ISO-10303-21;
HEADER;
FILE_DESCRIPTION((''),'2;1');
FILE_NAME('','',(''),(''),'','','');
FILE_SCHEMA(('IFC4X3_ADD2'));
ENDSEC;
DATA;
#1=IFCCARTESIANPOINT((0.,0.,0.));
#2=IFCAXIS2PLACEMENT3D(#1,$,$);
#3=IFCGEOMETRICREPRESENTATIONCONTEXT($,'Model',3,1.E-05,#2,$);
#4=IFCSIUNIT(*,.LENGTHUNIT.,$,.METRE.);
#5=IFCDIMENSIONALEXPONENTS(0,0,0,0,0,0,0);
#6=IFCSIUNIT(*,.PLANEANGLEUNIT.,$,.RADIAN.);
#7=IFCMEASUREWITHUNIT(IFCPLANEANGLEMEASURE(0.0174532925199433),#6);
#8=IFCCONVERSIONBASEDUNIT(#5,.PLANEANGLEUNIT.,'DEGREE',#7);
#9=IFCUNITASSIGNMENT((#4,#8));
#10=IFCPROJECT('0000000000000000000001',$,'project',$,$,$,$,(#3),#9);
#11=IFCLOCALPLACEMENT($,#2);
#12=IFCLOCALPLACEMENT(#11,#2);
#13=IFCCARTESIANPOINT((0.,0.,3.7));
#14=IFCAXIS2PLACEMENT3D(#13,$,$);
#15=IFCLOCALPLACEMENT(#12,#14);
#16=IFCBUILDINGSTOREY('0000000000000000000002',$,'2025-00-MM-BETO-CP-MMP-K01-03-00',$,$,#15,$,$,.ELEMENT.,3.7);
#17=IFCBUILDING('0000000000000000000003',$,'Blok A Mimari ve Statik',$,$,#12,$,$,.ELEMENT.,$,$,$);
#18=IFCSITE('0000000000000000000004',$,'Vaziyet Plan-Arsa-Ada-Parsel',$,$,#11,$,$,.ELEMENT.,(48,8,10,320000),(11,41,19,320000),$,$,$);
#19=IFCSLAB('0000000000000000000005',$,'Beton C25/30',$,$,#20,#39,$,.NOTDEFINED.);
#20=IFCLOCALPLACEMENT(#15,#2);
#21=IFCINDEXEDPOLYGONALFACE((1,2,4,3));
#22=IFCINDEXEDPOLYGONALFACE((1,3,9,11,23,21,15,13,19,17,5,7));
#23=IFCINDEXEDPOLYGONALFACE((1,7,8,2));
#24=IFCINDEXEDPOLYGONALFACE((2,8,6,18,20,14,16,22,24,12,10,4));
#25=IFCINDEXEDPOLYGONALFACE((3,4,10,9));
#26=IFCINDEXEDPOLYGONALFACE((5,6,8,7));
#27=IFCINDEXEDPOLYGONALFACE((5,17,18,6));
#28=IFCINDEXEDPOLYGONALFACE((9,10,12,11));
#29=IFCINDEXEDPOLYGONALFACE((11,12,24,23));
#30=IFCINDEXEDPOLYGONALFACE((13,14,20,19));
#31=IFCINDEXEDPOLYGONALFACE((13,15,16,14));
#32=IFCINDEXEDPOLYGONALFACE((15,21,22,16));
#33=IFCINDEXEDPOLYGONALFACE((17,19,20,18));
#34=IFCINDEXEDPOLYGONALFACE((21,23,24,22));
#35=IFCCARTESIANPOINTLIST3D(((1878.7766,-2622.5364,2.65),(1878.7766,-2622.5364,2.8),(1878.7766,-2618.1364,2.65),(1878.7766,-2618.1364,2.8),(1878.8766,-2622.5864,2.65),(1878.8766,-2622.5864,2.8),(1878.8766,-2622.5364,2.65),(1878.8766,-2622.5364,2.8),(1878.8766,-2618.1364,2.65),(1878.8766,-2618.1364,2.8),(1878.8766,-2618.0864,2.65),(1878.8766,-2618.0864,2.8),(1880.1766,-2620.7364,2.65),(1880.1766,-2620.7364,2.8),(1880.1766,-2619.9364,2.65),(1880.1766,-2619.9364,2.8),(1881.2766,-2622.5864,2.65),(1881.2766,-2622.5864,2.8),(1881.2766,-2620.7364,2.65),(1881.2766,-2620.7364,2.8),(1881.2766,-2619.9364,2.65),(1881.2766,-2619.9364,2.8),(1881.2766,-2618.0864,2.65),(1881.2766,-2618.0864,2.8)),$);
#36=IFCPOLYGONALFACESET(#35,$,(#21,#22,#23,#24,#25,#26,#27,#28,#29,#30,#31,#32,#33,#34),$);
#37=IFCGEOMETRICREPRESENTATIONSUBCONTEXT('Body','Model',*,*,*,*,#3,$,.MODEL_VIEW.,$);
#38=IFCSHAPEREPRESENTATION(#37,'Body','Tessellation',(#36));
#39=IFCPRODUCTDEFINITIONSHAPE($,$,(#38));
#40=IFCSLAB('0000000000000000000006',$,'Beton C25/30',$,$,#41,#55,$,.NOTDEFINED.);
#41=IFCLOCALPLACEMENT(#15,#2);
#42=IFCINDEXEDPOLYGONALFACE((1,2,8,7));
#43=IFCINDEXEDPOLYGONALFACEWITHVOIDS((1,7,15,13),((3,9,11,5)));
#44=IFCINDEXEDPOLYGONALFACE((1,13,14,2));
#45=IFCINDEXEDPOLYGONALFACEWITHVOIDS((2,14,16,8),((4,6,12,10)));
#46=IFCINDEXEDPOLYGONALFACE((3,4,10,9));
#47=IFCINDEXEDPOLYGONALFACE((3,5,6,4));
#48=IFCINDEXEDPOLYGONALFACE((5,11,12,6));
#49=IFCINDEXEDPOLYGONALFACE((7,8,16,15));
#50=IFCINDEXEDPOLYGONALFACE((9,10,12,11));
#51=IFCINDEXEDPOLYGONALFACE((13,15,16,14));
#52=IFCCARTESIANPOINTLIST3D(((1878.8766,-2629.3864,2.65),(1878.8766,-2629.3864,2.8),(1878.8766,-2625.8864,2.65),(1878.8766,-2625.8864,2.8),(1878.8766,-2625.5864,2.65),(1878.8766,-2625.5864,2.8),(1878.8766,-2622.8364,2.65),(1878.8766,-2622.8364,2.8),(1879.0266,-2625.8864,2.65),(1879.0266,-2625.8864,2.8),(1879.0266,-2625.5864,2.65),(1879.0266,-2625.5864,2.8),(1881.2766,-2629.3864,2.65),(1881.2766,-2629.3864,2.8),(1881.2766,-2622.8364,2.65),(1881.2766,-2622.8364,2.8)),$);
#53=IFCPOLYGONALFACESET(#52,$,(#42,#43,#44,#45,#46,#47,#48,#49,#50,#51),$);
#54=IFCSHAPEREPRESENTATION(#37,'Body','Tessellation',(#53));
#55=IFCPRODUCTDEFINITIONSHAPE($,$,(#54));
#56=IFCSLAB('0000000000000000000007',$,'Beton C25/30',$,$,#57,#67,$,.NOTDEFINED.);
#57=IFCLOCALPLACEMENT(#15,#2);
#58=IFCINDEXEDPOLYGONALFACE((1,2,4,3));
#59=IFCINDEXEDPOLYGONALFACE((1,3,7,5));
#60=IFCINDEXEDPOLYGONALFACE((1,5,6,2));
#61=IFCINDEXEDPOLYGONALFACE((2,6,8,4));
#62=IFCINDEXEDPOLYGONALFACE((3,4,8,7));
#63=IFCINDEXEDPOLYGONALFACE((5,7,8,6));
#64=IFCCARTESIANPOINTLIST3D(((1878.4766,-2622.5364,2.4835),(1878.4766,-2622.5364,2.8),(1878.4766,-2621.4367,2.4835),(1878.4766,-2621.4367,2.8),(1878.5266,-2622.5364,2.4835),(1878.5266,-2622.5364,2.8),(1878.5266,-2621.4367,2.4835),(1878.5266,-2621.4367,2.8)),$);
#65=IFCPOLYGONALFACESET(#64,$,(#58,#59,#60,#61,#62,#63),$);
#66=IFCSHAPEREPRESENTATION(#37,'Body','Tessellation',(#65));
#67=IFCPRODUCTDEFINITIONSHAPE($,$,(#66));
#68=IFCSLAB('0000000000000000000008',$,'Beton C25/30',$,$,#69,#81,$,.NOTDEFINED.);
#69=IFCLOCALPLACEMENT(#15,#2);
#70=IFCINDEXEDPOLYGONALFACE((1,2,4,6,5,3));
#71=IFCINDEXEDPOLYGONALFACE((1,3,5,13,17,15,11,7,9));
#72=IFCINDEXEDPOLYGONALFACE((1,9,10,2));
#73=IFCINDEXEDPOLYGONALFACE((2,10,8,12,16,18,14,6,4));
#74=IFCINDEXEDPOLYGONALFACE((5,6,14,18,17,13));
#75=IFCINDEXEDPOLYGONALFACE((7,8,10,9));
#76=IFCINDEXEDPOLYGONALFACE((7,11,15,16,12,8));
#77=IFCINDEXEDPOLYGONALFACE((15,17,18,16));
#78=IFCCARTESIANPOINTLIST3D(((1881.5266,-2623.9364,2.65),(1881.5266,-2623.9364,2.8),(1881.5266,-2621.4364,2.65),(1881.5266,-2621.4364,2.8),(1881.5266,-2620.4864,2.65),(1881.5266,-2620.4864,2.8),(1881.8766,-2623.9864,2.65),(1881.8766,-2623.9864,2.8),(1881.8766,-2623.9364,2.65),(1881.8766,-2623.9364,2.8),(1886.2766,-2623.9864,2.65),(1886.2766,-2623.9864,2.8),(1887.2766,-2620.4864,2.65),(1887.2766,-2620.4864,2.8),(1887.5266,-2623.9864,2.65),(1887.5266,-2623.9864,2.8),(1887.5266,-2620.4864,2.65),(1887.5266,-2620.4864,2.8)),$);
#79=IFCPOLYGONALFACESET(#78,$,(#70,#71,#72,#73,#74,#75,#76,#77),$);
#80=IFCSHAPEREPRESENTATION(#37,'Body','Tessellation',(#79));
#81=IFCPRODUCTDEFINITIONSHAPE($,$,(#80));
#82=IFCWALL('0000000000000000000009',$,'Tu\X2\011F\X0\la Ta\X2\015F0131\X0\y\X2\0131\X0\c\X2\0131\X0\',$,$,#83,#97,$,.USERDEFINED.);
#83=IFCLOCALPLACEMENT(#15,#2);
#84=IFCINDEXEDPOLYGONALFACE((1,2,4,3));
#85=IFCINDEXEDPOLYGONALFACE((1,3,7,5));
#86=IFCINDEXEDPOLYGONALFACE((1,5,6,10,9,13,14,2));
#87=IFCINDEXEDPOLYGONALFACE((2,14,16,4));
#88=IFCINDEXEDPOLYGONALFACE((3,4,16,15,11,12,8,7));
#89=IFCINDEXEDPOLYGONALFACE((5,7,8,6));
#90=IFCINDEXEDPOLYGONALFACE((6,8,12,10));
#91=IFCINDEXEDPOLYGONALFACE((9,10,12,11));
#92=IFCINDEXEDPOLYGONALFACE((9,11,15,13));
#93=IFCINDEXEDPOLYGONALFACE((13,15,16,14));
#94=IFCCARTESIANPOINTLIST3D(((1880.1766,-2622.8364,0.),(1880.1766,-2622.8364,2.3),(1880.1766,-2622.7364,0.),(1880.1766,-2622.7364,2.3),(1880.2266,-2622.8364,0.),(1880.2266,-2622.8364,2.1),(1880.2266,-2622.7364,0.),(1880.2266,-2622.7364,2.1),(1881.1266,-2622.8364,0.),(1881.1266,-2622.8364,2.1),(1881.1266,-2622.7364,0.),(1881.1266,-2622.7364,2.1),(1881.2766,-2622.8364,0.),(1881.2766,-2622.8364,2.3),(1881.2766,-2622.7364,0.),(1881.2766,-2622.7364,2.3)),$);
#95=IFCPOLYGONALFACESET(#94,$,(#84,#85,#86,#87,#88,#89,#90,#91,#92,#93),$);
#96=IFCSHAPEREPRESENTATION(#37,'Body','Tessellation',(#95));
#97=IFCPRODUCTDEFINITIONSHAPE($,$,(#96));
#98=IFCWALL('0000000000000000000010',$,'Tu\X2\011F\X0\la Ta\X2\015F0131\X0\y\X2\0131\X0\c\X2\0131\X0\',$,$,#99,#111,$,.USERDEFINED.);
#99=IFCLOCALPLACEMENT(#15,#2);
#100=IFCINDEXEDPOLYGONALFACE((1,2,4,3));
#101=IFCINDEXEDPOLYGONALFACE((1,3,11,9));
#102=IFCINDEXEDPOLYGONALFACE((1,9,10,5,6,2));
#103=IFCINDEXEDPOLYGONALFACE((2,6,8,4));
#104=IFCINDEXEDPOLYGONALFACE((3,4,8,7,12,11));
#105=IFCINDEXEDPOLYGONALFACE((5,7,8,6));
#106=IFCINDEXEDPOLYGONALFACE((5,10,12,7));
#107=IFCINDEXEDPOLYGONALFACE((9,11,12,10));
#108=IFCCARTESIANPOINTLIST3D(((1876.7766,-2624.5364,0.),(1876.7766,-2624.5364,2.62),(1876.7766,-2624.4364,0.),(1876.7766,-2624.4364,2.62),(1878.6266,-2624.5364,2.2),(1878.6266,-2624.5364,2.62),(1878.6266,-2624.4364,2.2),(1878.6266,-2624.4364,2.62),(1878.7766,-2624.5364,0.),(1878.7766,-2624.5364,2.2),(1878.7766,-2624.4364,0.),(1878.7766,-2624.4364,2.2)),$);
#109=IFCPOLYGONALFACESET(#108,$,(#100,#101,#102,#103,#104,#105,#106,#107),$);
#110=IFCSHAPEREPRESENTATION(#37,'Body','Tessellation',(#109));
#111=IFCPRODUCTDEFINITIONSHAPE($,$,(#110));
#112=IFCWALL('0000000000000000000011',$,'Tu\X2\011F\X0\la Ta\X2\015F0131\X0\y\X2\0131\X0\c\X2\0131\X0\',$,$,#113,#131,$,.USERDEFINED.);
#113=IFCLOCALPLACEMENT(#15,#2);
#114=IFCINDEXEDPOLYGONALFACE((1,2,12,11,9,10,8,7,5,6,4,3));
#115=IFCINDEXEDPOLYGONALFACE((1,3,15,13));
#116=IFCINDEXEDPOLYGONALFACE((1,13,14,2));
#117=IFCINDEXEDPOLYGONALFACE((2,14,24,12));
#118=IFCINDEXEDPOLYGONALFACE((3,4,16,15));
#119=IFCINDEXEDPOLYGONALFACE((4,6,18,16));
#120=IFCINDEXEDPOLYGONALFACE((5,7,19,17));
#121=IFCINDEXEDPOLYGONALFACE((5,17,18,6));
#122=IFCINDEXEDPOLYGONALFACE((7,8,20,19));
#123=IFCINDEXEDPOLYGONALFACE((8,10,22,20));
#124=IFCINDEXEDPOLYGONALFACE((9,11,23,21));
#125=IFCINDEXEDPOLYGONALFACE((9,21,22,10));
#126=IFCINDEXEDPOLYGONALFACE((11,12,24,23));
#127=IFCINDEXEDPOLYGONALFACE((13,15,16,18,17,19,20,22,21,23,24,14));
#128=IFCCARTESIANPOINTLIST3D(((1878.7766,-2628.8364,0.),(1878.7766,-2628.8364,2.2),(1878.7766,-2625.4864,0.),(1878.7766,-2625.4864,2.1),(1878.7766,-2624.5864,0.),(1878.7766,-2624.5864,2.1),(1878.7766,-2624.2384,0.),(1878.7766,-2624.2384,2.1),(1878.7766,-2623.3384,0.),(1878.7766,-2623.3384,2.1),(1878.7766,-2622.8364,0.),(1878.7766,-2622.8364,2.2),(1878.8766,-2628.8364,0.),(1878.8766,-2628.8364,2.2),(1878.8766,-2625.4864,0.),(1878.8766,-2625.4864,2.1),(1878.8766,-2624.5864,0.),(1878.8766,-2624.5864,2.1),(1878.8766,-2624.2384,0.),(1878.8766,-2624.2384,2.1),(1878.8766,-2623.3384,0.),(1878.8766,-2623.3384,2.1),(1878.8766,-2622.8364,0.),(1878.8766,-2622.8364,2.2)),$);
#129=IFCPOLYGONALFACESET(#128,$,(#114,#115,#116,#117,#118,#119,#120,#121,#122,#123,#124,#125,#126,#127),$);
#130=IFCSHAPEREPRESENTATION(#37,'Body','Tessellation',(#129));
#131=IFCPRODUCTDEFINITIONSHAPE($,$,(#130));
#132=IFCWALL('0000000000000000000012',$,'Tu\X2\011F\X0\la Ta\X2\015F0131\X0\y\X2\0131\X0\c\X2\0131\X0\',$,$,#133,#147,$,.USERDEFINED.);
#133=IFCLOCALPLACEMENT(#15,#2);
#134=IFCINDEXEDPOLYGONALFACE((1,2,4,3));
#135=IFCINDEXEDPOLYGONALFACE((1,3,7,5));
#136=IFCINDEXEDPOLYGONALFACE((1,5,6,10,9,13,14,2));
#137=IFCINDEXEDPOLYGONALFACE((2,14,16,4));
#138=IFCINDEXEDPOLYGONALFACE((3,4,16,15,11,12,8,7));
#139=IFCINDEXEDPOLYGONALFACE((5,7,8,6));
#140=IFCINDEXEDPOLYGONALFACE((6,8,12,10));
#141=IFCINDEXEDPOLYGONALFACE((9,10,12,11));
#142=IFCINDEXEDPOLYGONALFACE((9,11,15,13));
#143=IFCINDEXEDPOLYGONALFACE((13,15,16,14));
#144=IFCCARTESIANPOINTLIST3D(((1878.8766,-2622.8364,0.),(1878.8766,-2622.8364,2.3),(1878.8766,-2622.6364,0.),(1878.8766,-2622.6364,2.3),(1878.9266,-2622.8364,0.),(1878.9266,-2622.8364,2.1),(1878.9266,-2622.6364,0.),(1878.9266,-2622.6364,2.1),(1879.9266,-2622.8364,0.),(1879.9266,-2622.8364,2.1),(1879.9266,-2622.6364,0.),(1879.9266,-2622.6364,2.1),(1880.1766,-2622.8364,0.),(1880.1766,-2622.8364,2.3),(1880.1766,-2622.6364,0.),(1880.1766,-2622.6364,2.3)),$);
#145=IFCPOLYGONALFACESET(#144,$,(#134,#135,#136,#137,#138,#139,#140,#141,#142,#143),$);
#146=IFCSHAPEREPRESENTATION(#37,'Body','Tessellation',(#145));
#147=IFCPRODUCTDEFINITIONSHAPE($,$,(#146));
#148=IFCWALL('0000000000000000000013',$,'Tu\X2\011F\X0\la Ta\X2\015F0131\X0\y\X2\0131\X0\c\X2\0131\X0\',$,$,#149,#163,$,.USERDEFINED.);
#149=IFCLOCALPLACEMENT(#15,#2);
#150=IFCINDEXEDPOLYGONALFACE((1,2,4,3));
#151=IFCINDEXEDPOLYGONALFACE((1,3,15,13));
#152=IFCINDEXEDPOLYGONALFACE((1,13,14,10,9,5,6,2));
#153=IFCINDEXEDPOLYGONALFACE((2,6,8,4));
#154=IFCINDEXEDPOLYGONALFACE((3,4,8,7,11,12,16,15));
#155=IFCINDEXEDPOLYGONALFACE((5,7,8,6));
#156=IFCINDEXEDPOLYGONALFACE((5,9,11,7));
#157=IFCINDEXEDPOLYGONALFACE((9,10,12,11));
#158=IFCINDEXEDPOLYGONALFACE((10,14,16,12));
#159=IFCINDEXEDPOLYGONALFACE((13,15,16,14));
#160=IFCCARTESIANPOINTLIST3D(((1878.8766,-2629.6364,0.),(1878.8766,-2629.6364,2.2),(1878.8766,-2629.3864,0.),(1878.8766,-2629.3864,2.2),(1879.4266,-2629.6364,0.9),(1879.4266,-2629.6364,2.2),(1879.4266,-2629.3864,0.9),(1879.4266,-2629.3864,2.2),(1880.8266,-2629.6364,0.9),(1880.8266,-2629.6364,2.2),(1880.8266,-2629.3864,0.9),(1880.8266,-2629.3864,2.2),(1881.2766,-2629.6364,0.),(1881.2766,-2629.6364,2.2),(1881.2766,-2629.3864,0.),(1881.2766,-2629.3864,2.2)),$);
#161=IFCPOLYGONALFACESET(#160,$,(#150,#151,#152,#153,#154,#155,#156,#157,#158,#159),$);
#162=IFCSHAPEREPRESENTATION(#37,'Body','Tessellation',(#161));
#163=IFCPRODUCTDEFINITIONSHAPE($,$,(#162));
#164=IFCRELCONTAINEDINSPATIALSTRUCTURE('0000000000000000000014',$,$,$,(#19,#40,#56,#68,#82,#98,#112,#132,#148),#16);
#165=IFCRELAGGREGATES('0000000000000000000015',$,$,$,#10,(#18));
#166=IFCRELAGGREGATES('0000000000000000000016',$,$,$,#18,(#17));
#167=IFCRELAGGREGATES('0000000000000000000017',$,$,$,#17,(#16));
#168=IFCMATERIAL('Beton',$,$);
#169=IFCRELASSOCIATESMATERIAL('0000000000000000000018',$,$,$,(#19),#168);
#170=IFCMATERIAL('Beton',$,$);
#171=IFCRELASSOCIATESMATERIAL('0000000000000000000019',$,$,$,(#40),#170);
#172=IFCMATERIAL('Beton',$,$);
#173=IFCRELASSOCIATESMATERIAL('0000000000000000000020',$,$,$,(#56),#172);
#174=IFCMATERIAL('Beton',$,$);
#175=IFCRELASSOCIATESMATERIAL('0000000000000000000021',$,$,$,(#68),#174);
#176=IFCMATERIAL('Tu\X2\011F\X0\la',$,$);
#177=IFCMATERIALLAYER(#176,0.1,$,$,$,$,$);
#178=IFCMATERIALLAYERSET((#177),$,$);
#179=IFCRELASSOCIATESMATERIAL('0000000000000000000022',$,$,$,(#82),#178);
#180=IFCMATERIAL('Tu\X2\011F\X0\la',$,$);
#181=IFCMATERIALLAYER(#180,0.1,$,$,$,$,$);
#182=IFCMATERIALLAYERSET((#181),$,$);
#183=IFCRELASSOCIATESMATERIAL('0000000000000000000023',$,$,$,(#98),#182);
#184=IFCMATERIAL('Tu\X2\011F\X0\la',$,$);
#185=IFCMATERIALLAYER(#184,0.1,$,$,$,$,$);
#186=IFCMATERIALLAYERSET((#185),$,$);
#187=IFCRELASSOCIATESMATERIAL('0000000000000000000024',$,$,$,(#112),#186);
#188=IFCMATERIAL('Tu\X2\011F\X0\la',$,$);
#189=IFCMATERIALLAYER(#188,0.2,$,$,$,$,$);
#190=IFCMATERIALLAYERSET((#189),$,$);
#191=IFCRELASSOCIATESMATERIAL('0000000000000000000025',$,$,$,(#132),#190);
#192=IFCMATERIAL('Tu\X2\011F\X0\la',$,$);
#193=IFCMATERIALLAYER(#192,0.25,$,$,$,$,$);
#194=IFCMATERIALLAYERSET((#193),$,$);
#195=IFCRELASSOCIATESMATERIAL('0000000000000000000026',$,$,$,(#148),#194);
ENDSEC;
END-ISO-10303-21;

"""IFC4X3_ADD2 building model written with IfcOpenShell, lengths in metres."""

from ifc_helpers import new_model, entity, si_unit, converted_unit, frame, frame_2d, origin, origin_with_axes, place, context, subcontext, project, spatial, polyline, rectangle, outline, extrude, clip, bounded_halfspace, material, layer, layer_set, layer_usage, element, save


model = new_model("IFC4X3_ADD2")

# Units and contexts
model_context = context("Model", 3, precision=1e-05, world=origin())
body_context = subcontext(model_context, "Body", "Model", "MODEL_VIEW")
ifc_project = project(units=[si_unit("LENGTHUNIT", "METRE"), converted_unit("PLANEANGLEUNIT", "DEGREE", entity("IfcPlaneAngleMeasure", 0.0174532925199433), si_unit("PLANEANGLEUNIT", "RADIAN"), dimensions=[0, 0, 0, 0, 0, 0, 0])], contexts=[model_context])

# Site, building, storey
site_placement = place(None, origin())
site = spatial("IfcSite", under=ifc_project, at=site_placement, Name="Vaziyet Plan-Arsa-Ada-Parsel", CompositionType="ELEMENT", RefLatitude=(48, 8, 10, 320000), RefLongitude=(11, 41, 19, 320000))
building_placement = place(site_placement, origin())
building = spatial("IfcBuilding", under=site, at=building_placement, Name="Blok A Mimari ve Statik", CompositionType="ELEMENT")
storey_placement = place(building_placement, frame((0.0, 0.0, 3.7)))
storey = spatial("IfcBuildingStorey", under=building, at=storey_placement, Name="2025-00-MM-BETO-CP-MMP-K01-03-00", CompositionType="ELEMENT", Elevation=3.7)

# Slab, opening
ifc_material_1 = material(Name="Beton")
slab_1_placement = place(storey_placement, frame((1878.7766, -2622.5864, 2.65)))
slab_1 = element("IfcSlab", 1, at=slab_1_placement, inside=storey, material=ifc_material_1, Name="Beton C25/30", PredefinedType="NOTDEFINED", context=body_context, shape_type="SweptSolid", body=[
    extrude(outline(polyline([(0.1, 4.5), (0.1, 4.45), (0.0, 4.45), (0.0, 0.05), (0.1, 0.05), (0.1, 0.0), (2.5, 0.0), (2.5, 4.5), (0.1, 4.5)])), origin_with_axes(), (0.0, 0.0, 1.0), 0.15),
])
opening_1_placement = place(slab_1_placement, frame((1.4, 1.85, 0.0)))
element("IfcOpeningElement", 2, at=opening_1_placement, cuts=slab_1, PredefinedType="OPENING", context=body_context, shape_type="SweptSolid", body=[
    extrude(rectangle(XDim=1.1, YDim=0.8, at=frame_2d((0.0, 0.0), x_axis=(-1.0, 0.0))), frame((0.55, 0.4, 0.0), z_axis=(0.0, 0.0, 1.0), x_axis=(1.0, 0.0, 0.0)), (0.0, 0.0, 1.0), 0.15),
])

# Slabs
ifc_material_2 = material(Name="Beton")
slab_2_placement = place(storey_placement, frame((1878.8766, -2629.3864, 2.65)))
element("IfcSlab", 3, at=slab_2_placement, inside=storey, material=ifc_material_2, Name="Beton C25/30", PredefinedType="NOTDEFINED", context=body_context, shape_type="SweptSolid", body=[
    extrude(outline(polyline([(2.4, 6.55), (0.0, 6.55), (0.0, 0.0), (2.4, 0.0), (2.4, 6.55)]), holes=[polyline([(0.0, 3.8), (0.15, 3.8), (0.15, 3.5), (0.0, 3.5), (0.0, 3.8)])]), origin_with_axes(), (0.0, 0.0, 1.0), 0.15),
])
ifc_material_3 = material(Name="Beton")
slab_3_placement = place(storey_placement, frame((1878.4766, -2622.5364, 2.4835)))
element("IfcSlab", 4, at=slab_3_placement, inside=storey, material=ifc_material_3, Name="Beton C25/30", PredefinedType="NOTDEFINED", context=body_context, shape_type="SweptSolid", body=[
    extrude(rectangle(XDim=1.0997, YDim=0.05, at=frame_2d((0.025, -0.5498), x_axis=(0.0, -1.0))), frame((0.0, 1.0997, 0.0), z_axis=(0.0, 0.0, 1.0), x_axis=(1.0, 0.0, 0.0)), (0.0, 0.0, 1.0), 0.3165),
])
ifc_material_4 = material(Name="Beton")
slab_4_placement = place(storey_placement, frame((1881.5266, -2623.9864, 2.65)))
element("IfcSlab", 5, at=slab_4_placement, inside=storey, material=ifc_material_4, Name="Beton C25/30", PredefinedType="NOTDEFINED", context=body_context, shape_type="SweptSolid", body=[
    extrude(outline(polyline([(0.0, 3.5), (0.0, 2.55), (0.0, 0.05), (0.35, 0.05), (0.35, 0.0), (4.75, 0.0), (6.0, 0.0), (6.0, 3.5), (5.75, 3.5), (0.0, 3.5)])), origin_with_axes(), (0.0, 0.0, 1.0), 0.15),
])

# Wall, opening
ifc_material_5 = material(Name="Tuğla")
ifc_layer_1 = layer(ifc_material_5, 0.1)
ifc_layer_set_1 = layer_set([ifc_layer_1])
ifc_layer_usage_1 = layer_usage(ifc_layer_set_1, "AXIS2", "POSITIVE", 0.0)
wall_1_placement = place(storey_placement, frame((1880.1766, -2622.8364, 0.0), z_axis=(0.0, 0.0, 1.0), x_axis=(1.0, -0.000001, 0.0)))
wall_1 = element("IfcWall", 6, at=wall_1_placement, inside=storey, material=ifc_layer_usage_1, Name="Tuğla Taşıyıcı", PredefinedType="USERDEFINED", context=body_context, shape_type="SweptSolid", body=[
    extrude(rectangle(XDim=1.1, YDim=0.1, at=frame_2d((0.55, 0.05), x_axis=(1.0, 0.0))), origin_with_axes(), (0.0, 0.0, 1.0), 2.3),
])
opening_2_placement = place(wall_1_placement, frame((0.05, 0.0, 0.0), z_axis=(0.0, 1.0, 0.0), x_axis=(0.0, 0.0, 1.0)))
element("IfcOpeningElement", 7, at=opening_2_placement, cuts=wall_1, PredefinedType="OPENING", context=body_context, shape_type="SweptSolid", body=[
    extrude(outline(polyline([(2.1, 0.9), (2.1, 0.0), (0.0, 0.0), (0.0, 0.9), (2.1, 0.9)])), origin_with_axes(), (0.0, 0.0, 1.0), 0.1),
])

# Wall
ifc_material_6 = material(Name="Tuğla")
ifc_layer_2 = layer(ifc_material_6, 0.1)
ifc_layer_set_2 = layer_set([ifc_layer_2])
ifc_layer_usage_2 = layer_usage(ifc_layer_set_2, "AXIS2", "POSITIVE", 0.0)
wall_2_placement = place(storey_placement, frame((1876.7766, -2624.5364, 0.0)))
element("IfcWall", 8, at=wall_2_placement, inside=storey, material=ifc_layer_usage_2, Name="Tuğla Taşıyıcı", PredefinedType="USERDEFINED", context=body_context, shape_type="Clipping", body=[
    clip(extrude(rectangle(XDim=2.0, YDim=0.1, at=frame_2d((1.0, 0.05), x_axis=(1.0, 0.0))), origin_with_axes(), (0.0, 0.0, 1.0), 2.62), bounded_halfspace(frame((1.925, 0.05, 2.2), z_axis=(0.0, 0.0, -1.0), x_axis=(0.0, -1.0, 0.0)), True, origin_with_axes(), polyline([(1.85, 0.1), (1.85, 0.0), (2.0, 0.0), (2.0, 0.1), (1.85, 0.1)]))),
])

# Wall, openings
ifc_material_7 = material(Name="Tuğla")
ifc_layer_3 = layer(ifc_material_7, 0.1)
ifc_layer_set_3 = layer_set([ifc_layer_3])
ifc_layer_usage_3 = layer_usage(ifc_layer_set_3, "AXIS2", "POSITIVE", 0.0)
wall_3_placement = place(storey_placement, frame((1878.8766, -2628.8364, 0.0), z_axis=(0.0, 0.0, 1.0), x_axis=(0.0, 1.0, 0.0)))
wall_3 = element("IfcWall", 9, at=wall_3_placement, inside=storey, material=ifc_layer_usage_3, Name="Tuğla Taşıyıcı", PredefinedType="USERDEFINED", context=body_context, shape_type="SweptSolid", body=[
    extrude(rectangle(XDim=6.0, YDim=0.1, at=frame_2d((3.0, 0.05), x_axis=(1.0, 0.0))), origin_with_axes(), (0.0, 0.0, 1.0), 2.2),
])
opening_3_placement = place(wall_3_placement, frame((4.25, 0.1, 0.0), z_axis=(0.0, -1.0, 0.0), x_axis=(0.0, 0.0, 1.0)))
element("IfcOpeningElement", 10, at=opening_3_placement, cuts=wall_3, PredefinedType="OPENING", context=body_context, shape_type="SweptSolid", body=[
    extrude(outline(polyline([(2.1, 0.9), (2.1, 0.0), (0.0, 0.0), (0.0, 0.9), (2.1, 0.9)])), origin_with_axes(), (0.0, 0.0, 1.0), 0.1),
])
opening_4_placement = place(wall_3_placement, frame((5.498, 0.1, 0.0), z_axis=(0.0, -1.0, 0.0), x_axis=(0.0, 0.0, 1.0)))
element("IfcOpeningElement", 11, at=opening_4_placement, cuts=wall_3, PredefinedType="OPENING", context=body_context, shape_type="SweptSolid", body=[
    extrude(outline(polyline([(2.1, 0.9), (2.1, 0.0), (0.0, 0.0), (0.0, 0.9), (2.1, 0.9)])), origin_with_axes(), (0.0, 0.0, 1.0), 0.1),
])

# Walls, openings
ifc_material_8 = material(Name="Tuğla")
ifc_layer_4 = layer(ifc_material_8, 0.2)
ifc_layer_set_4 = layer_set([ifc_layer_4])
ifc_layer_usage_4 = layer_usage(ifc_layer_set_4, "AXIS2", "POSITIVE", 0.0)
wall_4_placement = place(storey_placement, frame((1878.8766, -2622.8364, 0.0), z_axis=(0.0, 0.0, 1.0), x_axis=(1.0, 0.000001, 0.0)))
wall_4 = element("IfcWall", 12, at=wall_4_placement, inside=storey, material=ifc_layer_usage_4, Name="Tuğla Taşıyıcı", PredefinedType="USERDEFINED", context=body_context, shape_type="SweptSolid", body=[
    extrude(rectangle(XDim=1.3, YDim=0.2, at=frame_2d((0.65, 0.1), x_axis=(1.0, 0.0))), origin_with_axes(), (0.0, 0.0, 1.0), 2.3),
])
opening_5_placement = place(wall_4_placement, frame((0.05, 0.0, 0.0), z_axis=(0.0, 1.0, 0.0), x_axis=(0.0, 0.0, 1.0)))
element("IfcOpeningElement", 13, at=opening_5_placement, cuts=wall_4, PredefinedType="OPENING", context=body_context, shape_type="SweptSolid", body=[
    extrude(outline(polyline([(2.1, 1.0), (2.1, 0.0), (0.0, 0.0), (0.0, 1.0), (2.1, 1.0)])), origin_with_axes(), (0.0, 0.0, 1.0), 0.2),
])
ifc_material_9 = material(Name="Tuğla")
ifc_layer_5 = layer(ifc_material_9, 0.25)
ifc_layer_set_5 = layer_set([ifc_layer_5])
ifc_layer_usage_5 = layer_usage(ifc_layer_set_5, "AXIS2", "POSITIVE", 0.0)
wall_5_placement = place(storey_placement, frame((1878.8766, -2629.6364, 0.0)))
wall_5 = element("IfcWall", 14, at=wall_5_placement, inside=storey, material=ifc_layer_usage_5, Name="Tuğla Taşıyıcı", PredefinedType="USERDEFINED", context=body_context, shape_type="SweptSolid", body=[
    extrude(rectangle(XDim=2.4, YDim=0.25, at=frame_2d((1.2, 0.125), x_axis=(1.0, 0.0))), origin_with_axes(), (0.0, 0.0, 1.0), 2.2),
])
opening_6_placement = place(wall_5_placement, frame((0.55, 0.0, 0.9), z_axis=(0.0, 1.0, 0.0), x_axis=(0.0, 0.0, 1.0)))
element("IfcOpeningElement", 15, at=opening_6_placement, cuts=wall_5, PredefinedType="OPENING", context=body_context, shape_type="SweptSolid", body=[
    extrude(outline(polyline([(1.35, 1.4), (1.35, 0.0), (0.0, 0.0), (0.0, 1.4), (1.35, 1.4)])), origin_with_axes(), (0.0, 0.0, 1.0), 0.25),
])

save(model, "model.ifc")
